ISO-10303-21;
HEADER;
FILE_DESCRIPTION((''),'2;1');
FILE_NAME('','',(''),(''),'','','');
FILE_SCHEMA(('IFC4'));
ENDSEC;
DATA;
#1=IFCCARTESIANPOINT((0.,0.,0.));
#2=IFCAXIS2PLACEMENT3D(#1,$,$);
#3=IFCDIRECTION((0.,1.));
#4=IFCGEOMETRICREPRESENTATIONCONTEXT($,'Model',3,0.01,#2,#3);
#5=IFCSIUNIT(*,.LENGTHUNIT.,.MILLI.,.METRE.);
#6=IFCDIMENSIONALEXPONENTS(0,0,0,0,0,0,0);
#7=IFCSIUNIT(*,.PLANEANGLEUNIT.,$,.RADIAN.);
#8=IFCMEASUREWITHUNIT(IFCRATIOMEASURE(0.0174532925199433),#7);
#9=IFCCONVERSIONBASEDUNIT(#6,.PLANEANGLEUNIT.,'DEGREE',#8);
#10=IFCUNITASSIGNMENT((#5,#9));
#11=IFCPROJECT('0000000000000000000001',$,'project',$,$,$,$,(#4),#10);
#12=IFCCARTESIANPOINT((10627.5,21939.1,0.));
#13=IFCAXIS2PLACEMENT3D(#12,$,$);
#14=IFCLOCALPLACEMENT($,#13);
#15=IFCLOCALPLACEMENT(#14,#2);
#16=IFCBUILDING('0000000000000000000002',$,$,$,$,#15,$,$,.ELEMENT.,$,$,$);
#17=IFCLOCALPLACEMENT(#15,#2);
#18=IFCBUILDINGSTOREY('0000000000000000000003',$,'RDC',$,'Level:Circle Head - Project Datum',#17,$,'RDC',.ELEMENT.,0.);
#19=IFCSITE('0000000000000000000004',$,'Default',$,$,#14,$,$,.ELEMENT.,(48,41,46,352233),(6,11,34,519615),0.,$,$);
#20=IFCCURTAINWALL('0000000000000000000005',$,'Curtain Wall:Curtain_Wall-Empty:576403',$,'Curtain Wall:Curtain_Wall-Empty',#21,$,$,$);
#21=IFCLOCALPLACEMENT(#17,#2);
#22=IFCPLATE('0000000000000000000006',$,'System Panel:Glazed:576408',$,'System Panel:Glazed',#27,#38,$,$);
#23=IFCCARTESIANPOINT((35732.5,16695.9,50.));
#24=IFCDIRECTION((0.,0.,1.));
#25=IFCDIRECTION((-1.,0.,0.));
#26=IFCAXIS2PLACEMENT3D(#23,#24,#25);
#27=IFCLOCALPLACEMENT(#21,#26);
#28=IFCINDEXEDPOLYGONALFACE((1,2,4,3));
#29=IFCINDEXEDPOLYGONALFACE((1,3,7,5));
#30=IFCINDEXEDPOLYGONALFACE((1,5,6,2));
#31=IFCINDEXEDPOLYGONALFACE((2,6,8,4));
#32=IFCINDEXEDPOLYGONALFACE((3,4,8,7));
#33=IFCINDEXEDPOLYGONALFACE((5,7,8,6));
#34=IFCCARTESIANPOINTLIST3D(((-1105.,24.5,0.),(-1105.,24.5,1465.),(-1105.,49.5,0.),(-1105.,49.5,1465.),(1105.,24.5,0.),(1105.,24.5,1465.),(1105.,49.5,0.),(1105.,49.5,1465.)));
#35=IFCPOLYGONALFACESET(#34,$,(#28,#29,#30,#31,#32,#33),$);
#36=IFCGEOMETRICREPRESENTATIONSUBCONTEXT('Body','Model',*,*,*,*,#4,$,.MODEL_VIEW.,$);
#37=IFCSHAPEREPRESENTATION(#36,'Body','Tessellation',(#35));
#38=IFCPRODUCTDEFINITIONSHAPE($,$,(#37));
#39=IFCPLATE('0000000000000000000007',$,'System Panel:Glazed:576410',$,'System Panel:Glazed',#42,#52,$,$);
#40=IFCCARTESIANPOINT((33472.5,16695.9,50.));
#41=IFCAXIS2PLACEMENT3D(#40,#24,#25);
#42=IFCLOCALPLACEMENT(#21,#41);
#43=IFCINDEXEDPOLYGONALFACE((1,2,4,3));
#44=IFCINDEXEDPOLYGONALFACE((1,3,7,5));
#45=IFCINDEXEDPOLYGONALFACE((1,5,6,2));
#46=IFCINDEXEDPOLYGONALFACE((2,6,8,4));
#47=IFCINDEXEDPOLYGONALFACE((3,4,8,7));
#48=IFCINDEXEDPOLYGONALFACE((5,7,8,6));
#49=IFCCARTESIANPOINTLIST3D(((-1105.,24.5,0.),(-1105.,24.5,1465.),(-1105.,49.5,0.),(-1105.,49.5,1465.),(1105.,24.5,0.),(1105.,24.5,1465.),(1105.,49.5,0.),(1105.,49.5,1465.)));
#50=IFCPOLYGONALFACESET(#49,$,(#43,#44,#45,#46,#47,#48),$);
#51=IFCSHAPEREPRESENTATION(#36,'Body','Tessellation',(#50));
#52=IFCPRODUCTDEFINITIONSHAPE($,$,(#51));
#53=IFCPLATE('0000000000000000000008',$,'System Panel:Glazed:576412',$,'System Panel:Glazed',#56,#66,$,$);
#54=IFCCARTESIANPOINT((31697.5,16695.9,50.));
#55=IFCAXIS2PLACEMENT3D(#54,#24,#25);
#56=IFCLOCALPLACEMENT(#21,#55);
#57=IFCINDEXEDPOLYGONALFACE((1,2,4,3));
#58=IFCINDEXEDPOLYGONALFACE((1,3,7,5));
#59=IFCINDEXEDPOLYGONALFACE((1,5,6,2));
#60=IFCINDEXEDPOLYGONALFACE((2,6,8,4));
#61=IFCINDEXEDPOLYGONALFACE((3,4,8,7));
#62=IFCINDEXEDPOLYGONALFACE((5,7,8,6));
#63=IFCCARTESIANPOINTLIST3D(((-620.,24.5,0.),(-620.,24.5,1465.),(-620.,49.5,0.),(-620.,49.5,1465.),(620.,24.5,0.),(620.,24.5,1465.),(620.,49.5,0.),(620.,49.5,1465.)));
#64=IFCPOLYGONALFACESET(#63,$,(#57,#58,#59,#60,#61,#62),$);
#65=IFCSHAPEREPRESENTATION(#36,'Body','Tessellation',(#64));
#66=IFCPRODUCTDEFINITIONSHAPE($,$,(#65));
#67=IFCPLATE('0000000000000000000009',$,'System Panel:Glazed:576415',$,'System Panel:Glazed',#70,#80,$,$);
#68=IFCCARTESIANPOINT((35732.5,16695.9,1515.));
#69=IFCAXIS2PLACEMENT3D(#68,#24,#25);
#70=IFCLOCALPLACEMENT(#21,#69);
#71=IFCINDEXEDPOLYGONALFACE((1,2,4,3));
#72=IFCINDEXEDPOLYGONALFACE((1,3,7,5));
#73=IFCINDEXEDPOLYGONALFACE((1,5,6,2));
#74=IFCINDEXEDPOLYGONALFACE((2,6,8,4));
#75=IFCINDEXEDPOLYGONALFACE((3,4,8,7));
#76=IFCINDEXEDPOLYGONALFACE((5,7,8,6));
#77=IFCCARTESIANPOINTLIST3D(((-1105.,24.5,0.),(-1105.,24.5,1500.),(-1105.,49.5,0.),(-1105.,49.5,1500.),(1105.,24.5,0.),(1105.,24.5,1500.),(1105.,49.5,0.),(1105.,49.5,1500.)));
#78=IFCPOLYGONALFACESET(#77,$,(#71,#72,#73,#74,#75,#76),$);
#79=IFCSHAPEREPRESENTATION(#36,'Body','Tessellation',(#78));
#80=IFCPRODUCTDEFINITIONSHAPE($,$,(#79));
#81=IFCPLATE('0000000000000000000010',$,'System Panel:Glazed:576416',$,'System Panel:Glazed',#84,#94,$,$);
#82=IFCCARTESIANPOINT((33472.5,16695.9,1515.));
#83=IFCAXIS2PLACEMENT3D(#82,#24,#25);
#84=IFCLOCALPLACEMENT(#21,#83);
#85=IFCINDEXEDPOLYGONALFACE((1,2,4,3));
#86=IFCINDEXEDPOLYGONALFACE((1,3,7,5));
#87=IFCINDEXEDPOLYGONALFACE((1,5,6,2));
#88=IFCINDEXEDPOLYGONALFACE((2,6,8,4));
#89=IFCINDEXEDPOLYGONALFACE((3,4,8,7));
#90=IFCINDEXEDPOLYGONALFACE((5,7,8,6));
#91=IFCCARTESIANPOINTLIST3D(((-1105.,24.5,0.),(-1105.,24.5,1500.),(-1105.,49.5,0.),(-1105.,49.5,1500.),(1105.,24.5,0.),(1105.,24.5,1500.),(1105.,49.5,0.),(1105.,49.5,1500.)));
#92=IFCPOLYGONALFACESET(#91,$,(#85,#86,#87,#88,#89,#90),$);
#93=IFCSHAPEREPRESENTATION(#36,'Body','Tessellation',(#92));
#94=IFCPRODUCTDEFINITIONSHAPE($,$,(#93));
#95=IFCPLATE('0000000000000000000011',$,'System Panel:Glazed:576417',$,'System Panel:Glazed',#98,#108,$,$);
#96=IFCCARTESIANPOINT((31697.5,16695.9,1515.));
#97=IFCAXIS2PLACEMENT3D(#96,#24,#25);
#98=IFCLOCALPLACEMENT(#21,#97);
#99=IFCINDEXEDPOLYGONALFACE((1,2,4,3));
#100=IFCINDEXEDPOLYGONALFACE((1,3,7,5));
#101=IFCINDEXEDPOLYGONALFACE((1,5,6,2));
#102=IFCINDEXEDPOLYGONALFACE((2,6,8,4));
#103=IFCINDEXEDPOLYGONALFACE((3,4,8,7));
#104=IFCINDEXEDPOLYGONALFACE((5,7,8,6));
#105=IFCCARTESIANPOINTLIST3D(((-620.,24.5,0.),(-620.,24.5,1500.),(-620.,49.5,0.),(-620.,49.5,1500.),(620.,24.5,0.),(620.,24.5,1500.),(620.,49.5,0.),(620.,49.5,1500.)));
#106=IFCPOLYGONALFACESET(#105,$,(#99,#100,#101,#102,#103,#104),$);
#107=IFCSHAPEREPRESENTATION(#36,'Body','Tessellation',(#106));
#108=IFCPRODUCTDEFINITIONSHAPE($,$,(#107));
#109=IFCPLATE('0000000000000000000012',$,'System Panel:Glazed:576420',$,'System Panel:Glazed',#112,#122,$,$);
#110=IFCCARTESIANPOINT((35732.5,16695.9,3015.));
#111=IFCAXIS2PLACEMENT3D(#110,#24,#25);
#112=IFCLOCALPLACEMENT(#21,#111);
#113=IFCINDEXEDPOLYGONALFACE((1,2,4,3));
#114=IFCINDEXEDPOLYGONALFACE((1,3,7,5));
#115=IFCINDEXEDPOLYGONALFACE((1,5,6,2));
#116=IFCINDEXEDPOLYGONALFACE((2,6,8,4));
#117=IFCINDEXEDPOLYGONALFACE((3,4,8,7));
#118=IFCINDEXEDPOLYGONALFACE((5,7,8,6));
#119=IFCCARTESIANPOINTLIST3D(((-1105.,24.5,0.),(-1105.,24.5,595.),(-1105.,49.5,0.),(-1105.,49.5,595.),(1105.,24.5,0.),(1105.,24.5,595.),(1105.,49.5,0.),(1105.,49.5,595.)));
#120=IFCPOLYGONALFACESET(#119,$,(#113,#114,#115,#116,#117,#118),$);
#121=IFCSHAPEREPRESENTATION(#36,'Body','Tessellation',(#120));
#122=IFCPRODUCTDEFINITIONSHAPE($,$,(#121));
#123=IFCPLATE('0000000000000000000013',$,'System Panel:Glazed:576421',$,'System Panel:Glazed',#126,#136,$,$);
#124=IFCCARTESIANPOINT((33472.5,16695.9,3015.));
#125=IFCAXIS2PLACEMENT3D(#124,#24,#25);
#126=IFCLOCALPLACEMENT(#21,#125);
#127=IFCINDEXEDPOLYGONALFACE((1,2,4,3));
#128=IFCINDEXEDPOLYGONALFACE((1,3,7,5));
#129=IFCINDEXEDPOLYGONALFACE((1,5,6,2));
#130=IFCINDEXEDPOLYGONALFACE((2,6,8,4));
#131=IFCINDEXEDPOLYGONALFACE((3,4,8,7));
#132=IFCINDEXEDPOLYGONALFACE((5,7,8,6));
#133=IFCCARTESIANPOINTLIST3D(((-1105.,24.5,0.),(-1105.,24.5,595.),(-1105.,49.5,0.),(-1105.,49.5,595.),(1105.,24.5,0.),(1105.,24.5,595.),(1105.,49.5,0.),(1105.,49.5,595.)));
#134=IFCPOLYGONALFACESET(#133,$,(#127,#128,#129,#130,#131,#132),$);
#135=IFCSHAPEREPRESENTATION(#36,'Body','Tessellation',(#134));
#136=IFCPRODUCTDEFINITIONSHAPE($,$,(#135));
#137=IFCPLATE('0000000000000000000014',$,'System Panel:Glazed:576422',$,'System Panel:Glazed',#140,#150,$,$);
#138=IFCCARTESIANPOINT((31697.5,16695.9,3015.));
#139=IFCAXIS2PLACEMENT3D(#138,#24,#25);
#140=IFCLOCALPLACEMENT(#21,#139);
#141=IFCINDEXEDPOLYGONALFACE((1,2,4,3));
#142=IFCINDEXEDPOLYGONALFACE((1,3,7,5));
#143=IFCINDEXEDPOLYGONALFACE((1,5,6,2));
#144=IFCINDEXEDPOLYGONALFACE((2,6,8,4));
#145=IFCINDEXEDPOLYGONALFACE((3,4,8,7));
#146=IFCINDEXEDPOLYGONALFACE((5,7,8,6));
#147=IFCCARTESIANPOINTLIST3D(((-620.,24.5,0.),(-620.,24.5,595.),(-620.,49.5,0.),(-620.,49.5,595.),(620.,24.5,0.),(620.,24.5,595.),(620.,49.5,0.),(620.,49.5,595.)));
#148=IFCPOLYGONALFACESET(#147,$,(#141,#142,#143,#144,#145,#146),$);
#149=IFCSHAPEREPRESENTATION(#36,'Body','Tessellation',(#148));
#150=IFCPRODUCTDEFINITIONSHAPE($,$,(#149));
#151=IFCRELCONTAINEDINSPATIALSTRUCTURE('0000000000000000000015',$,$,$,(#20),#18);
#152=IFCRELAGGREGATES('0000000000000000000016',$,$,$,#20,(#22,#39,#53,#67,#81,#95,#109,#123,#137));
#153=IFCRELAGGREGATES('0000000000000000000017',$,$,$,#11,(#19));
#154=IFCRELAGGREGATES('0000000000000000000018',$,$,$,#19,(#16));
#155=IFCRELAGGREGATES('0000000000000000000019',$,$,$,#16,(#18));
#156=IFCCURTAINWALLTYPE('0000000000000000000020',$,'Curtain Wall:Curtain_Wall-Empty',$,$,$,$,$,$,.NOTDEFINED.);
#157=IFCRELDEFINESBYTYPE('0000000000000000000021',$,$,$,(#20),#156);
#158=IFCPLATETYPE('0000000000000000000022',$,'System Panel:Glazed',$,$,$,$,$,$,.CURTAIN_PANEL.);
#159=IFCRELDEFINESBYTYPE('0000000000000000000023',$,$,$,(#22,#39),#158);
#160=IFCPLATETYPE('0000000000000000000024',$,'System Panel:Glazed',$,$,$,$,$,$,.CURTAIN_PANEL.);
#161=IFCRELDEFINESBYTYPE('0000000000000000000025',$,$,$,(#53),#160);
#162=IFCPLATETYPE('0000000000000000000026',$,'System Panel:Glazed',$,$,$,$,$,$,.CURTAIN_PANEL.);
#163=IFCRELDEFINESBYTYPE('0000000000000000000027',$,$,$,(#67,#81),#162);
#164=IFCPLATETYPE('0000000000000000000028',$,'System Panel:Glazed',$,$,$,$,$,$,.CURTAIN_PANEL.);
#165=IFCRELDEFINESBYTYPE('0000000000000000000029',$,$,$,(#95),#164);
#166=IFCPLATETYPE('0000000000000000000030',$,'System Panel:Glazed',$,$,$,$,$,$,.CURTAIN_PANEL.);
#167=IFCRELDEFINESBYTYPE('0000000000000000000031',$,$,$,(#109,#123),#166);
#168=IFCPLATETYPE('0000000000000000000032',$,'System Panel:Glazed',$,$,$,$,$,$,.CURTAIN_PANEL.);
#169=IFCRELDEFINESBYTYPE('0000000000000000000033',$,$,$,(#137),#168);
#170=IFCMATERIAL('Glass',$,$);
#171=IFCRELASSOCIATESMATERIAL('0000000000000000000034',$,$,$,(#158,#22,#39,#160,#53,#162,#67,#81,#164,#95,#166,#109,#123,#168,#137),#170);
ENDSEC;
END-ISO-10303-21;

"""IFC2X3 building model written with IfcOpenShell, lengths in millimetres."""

from ifc_helpers import new_model, entity, si_unit, converted_unit, direction, frame, origin, origin_2d_with_axis, place, context, subcontext, project, spatial, rectangle, extrude, source, transform, mapped, material, type_object, type_shapes, element, aggregate, save


model = new_model("IFC2X3")

# Units and contexts
model_context = context("Model", 3, precision=0.01, world=origin(), true_north=direction((0.0, 1.0)))
body_context = subcontext(model_context, "Body", "Model", "MODEL_VIEW")
ifc_project = project(units=[si_unit("LENGTHUNIT", "METRE", prefix="MILLI"), converted_unit("PLANEANGLEUNIT", "DEGREE", entity("IfcRatioMeasure", 0.0174532925199433), si_unit("PLANEANGLEUNIT", "RADIAN"), dimensions=[0, 0, 0, 0, 0, 0, 0])], contexts=[model_context])

# Site, building, storey
site_placement = place(None, frame((10627.5, 21939.1, 0.0)))
site = spatial("IfcSite", under=ifc_project, at=site_placement, Name="Default", CompositionType="ELEMENT", RefLatitude=(48, 41, 46, 352233), RefLongitude=(6, 11, 34, 519615), RefElevation=0.0)
building_placement = place(site_placement, origin())
building = spatial("IfcBuilding", under=site, at=building_placement, CompositionType="ELEMENT")
storey_placement = place(building_placement, origin())
storey = spatial("IfcBuildingStorey", under=building, at=storey_placement, Name="RDC", ObjectType="Level:Circle Head - Project Datum", LongName="RDC", CompositionType="ELEMENT", Elevation=0.0)

# Curtain wall, plates
curtain_wall_type = type_object("IfcCurtainWallType", Name="Curtain Wall:Curtain_Wall-Empty", PredefinedType="NOTDEFINED")
curtain_wall_placement = place(storey_placement, origin())
curtain_wall = element("IfcCurtainWall", 1, at=curtain_wall_placement, inside=storey, type_object=curtain_wall_type, Name="Curtain Wall:Curtain_Wall-Empty:576403", ObjectType="Curtain Wall:Curtain_Wall-Empty")
ifc_material_1 = material(Name="Glass")
plate_type_1 = type_object("IfcPlateType", Name="System Panel:Glazed", PredefinedType="CURTAIN_PANEL", material=ifc_material_1)
shared_shape_1 = source(origin(), body_context, "Body", "SweptSolid", [
    extrude(rectangle(XDim=25.0, YDim=2210.0, at=origin_2d_with_axis()), frame((0.0, 37.0, 0.0), z_axis=(0.0, 0.0, 1.0), x_axis=(0.0, 1.0, 0.0)), (0.0, 0.0, 1.0), 1465.0),
])
type_shapes(plate_type_1, [shared_shape_1])
plate_1_placement = place(curtain_wall_placement, frame((35732.5, 16695.9, 50.0), z_axis=(0.0, 0.0, 1.0), x_axis=(-1.0, 0.0, 0.0)))
plate_1 = element("IfcPlate", 2, at=plate_1_placement, type_object=plate_type_1, material=ifc_material_1, Name="System Panel:Glazed:576408", ObjectType="System Panel:Glazed", context=body_context, shape_type="MappedRepresentation", body=[
    mapped(shared_shape_1, transform((0.0, 0.0, 0.0), scale=1.0)),
])
plate_2_placement = place(curtain_wall_placement, frame((33472.5, 16695.9, 50.0), z_axis=(0.0, 0.0, 1.0), x_axis=(-1.0, 0.0, 0.0)))
plate_2 = element("IfcPlate", 3, at=plate_2_placement, type_object=plate_type_1, material=ifc_material_1, Name="System Panel:Glazed:576410", ObjectType="System Panel:Glazed", context=body_context, shape_type="MappedRepresentation", body=[
    mapped(shared_shape_1, transform((0.0, 0.0, 0.0), scale=1.0)),
])
plate_type_2 = type_object("IfcPlateType", Name="System Panel:Glazed", PredefinedType="CURTAIN_PANEL", material=ifc_material_1)
shared_shape_2 = source(origin(), body_context, "Body", "SweptSolid", [
    extrude(rectangle(XDim=25.0, YDim=1240.0, at=origin_2d_with_axis()), frame((0.0, 37.0, 0.0), z_axis=(0.0, 0.0, 1.0), x_axis=(0.0, 1.0, 0.0)), (0.0, 0.0, 1.0), 1465.0),
])
type_shapes(plate_type_2, [shared_shape_2])
plate_3_placement = place(curtain_wall_placement, frame((31697.5, 16695.9, 50.0), z_axis=(0.0, 0.0, 1.0), x_axis=(-1.0, 0.0, 0.0)))
plate_3 = element("IfcPlate", 4, at=plate_3_placement, type_object=plate_type_2, material=ifc_material_1, Name="System Panel:Glazed:576412", ObjectType="System Panel:Glazed", context=body_context, shape_type="MappedRepresentation", body=[
    mapped(shared_shape_2, transform((0.0, 0.0, 0.0), scale=1.0)),
])
plate_type_3 = type_object("IfcPlateType", Name="System Panel:Glazed", PredefinedType="CURTAIN_PANEL", material=ifc_material_1)
shared_shape_3 = source(origin(), body_context, "Body", "SweptSolid", [
    extrude(rectangle(XDim=25.0, YDim=2210.0, at=origin_2d_with_axis()), frame((0.0, 37.0, 0.0), z_axis=(0.0, 0.0, 1.0), x_axis=(0.0, 1.0, 0.0)), (0.0, 0.0, 1.0), 1500.0),
])
type_shapes(plate_type_3, [shared_shape_3])
plate_4_placement = place(curtain_wall_placement, frame((35732.5, 16695.9, 1515.0), z_axis=(0.0, 0.0, 1.0), x_axis=(-1.0, 0.0, 0.0)))
plate_4 = element("IfcPlate", 5, at=plate_4_placement, type_object=plate_type_3, material=ifc_material_1, Name="System Panel:Glazed:576415", ObjectType="System Panel:Glazed", context=body_context, shape_type="MappedRepresentation", body=[
    mapped(shared_shape_3, transform((0.0, 0.0, 0.0), scale=1.0)),
])
plate_5_placement = place(curtain_wall_placement, frame((33472.5, 16695.9, 1515.0), z_axis=(0.0, 0.0, 1.0), x_axis=(-1.0, 0.0, 0.0)))
plate_5 = element("IfcPlate", 6, at=plate_5_placement, type_object=plate_type_3, material=ifc_material_1, Name="System Panel:Glazed:576416", ObjectType="System Panel:Glazed", context=body_context, shape_type="MappedRepresentation", body=[
    mapped(shared_shape_3, transform((0.0, 0.0, 0.0), scale=1.0)),
])
plate_type_4 = type_object("IfcPlateType", Name="System Panel:Glazed", PredefinedType="CURTAIN_PANEL", material=ifc_material_1)
shared_shape_4 = source(origin(), body_context, "Body", "SweptSolid", [
    extrude(rectangle(XDim=25.0, YDim=1240.0, at=origin_2d_with_axis()), frame((0.0, 37.0, 0.0), z_axis=(0.0, 0.0, 1.0), x_axis=(0.0, 1.0, 0.0)), (0.0, 0.0, 1.0), 1500.0),
])
type_shapes(plate_type_4, [shared_shape_4])
plate_6_placement = place(curtain_wall_placement, frame((31697.5, 16695.9, 1515.0), z_axis=(0.0, 0.0, 1.0), x_axis=(-1.0, 0.0, 0.0)))
plate_6 = element("IfcPlate", 7, at=plate_6_placement, type_object=plate_type_4, material=ifc_material_1, Name="System Panel:Glazed:576417", ObjectType="System Panel:Glazed", context=body_context, shape_type="MappedRepresentation", body=[
    mapped(shared_shape_4, transform((0.0, 0.0, 0.0), scale=1.0)),
])
plate_type_5 = type_object("IfcPlateType", Name="System Panel:Glazed", PredefinedType="CURTAIN_PANEL", material=ifc_material_1)
shared_shape_5 = source(origin(), body_context, "Body", "SweptSolid", [
    extrude(rectangle(XDim=25.0, YDim=2210.0, at=origin_2d_with_axis()), frame((0.0, 37.0, 0.0), z_axis=(0.0, 0.0, 1.0), x_axis=(0.0, 1.0, 0.0)), (0.0, 0.0, 1.0), 595.0),
])
type_shapes(plate_type_5, [shared_shape_5])
plate_7_placement = place(curtain_wall_placement, frame((35732.5, 16695.9, 3015.0), z_axis=(0.0, 0.0, 1.0), x_axis=(-1.0, 0.0, 0.0)))
plate_7 = element("IfcPlate", 8, at=plate_7_placement, type_object=plate_type_5, material=ifc_material_1, Name="System Panel:Glazed:576420", ObjectType="System Panel:Glazed", context=body_context, shape_type="MappedRepresentation", body=[
    mapped(shared_shape_5, transform((0.0, 0.0, 0.0), scale=1.0)),
])
plate_8_placement = place(curtain_wall_placement, frame((33472.5, 16695.9, 3015.0), z_axis=(0.0, 0.0, 1.0), x_axis=(-1.0, 0.0, 0.0)))
plate_8 = element("IfcPlate", 9, at=plate_8_placement, type_object=plate_type_5, material=ifc_material_1, Name="System Panel:Glazed:576421", ObjectType="System Panel:Glazed", context=body_context, shape_type="MappedRepresentation", body=[
    mapped(shared_shape_5, transform((0.0, 0.0, 0.0), scale=1.0)),
])
plate_type_6 = type_object("IfcPlateType", Name="System Panel:Glazed", PredefinedType="CURTAIN_PANEL", material=ifc_material_1)
shared_shape_6 = source(origin(), body_context, "Body", "SweptSolid", [
    extrude(rectangle(XDim=25.0, YDim=1240.0, at=origin_2d_with_axis()), frame((0.0, 37.0, 0.0), z_axis=(0.0, 0.0, 1.0), x_axis=(0.0, 1.0, 0.0)), (0.0, 0.0, 1.0), 595.0),
])
type_shapes(plate_type_6, [shared_shape_6])
plate_9_placement = place(curtain_wall_placement, frame((31697.5, 16695.9, 3015.0), z_axis=(0.0, 0.0, 1.0), x_axis=(-1.0, 0.0, 0.0)))
plate_9 = element("IfcPlate", 10, at=plate_9_placement, type_object=plate_type_6, material=ifc_material_1, Name="System Panel:Glazed:576422", ObjectType="System Panel:Glazed", context=body_context, shape_type="MappedRepresentation", body=[
    mapped(shared_shape_6, transform((0.0, 0.0, 0.0), scale=1.0)),
])
aggregate(curtain_wall, [plate_1, plate_2, plate_3, plate_4, plate_5, plate_6, plate_7, plate_8, plate_9])

save(model, "model.ifc")
